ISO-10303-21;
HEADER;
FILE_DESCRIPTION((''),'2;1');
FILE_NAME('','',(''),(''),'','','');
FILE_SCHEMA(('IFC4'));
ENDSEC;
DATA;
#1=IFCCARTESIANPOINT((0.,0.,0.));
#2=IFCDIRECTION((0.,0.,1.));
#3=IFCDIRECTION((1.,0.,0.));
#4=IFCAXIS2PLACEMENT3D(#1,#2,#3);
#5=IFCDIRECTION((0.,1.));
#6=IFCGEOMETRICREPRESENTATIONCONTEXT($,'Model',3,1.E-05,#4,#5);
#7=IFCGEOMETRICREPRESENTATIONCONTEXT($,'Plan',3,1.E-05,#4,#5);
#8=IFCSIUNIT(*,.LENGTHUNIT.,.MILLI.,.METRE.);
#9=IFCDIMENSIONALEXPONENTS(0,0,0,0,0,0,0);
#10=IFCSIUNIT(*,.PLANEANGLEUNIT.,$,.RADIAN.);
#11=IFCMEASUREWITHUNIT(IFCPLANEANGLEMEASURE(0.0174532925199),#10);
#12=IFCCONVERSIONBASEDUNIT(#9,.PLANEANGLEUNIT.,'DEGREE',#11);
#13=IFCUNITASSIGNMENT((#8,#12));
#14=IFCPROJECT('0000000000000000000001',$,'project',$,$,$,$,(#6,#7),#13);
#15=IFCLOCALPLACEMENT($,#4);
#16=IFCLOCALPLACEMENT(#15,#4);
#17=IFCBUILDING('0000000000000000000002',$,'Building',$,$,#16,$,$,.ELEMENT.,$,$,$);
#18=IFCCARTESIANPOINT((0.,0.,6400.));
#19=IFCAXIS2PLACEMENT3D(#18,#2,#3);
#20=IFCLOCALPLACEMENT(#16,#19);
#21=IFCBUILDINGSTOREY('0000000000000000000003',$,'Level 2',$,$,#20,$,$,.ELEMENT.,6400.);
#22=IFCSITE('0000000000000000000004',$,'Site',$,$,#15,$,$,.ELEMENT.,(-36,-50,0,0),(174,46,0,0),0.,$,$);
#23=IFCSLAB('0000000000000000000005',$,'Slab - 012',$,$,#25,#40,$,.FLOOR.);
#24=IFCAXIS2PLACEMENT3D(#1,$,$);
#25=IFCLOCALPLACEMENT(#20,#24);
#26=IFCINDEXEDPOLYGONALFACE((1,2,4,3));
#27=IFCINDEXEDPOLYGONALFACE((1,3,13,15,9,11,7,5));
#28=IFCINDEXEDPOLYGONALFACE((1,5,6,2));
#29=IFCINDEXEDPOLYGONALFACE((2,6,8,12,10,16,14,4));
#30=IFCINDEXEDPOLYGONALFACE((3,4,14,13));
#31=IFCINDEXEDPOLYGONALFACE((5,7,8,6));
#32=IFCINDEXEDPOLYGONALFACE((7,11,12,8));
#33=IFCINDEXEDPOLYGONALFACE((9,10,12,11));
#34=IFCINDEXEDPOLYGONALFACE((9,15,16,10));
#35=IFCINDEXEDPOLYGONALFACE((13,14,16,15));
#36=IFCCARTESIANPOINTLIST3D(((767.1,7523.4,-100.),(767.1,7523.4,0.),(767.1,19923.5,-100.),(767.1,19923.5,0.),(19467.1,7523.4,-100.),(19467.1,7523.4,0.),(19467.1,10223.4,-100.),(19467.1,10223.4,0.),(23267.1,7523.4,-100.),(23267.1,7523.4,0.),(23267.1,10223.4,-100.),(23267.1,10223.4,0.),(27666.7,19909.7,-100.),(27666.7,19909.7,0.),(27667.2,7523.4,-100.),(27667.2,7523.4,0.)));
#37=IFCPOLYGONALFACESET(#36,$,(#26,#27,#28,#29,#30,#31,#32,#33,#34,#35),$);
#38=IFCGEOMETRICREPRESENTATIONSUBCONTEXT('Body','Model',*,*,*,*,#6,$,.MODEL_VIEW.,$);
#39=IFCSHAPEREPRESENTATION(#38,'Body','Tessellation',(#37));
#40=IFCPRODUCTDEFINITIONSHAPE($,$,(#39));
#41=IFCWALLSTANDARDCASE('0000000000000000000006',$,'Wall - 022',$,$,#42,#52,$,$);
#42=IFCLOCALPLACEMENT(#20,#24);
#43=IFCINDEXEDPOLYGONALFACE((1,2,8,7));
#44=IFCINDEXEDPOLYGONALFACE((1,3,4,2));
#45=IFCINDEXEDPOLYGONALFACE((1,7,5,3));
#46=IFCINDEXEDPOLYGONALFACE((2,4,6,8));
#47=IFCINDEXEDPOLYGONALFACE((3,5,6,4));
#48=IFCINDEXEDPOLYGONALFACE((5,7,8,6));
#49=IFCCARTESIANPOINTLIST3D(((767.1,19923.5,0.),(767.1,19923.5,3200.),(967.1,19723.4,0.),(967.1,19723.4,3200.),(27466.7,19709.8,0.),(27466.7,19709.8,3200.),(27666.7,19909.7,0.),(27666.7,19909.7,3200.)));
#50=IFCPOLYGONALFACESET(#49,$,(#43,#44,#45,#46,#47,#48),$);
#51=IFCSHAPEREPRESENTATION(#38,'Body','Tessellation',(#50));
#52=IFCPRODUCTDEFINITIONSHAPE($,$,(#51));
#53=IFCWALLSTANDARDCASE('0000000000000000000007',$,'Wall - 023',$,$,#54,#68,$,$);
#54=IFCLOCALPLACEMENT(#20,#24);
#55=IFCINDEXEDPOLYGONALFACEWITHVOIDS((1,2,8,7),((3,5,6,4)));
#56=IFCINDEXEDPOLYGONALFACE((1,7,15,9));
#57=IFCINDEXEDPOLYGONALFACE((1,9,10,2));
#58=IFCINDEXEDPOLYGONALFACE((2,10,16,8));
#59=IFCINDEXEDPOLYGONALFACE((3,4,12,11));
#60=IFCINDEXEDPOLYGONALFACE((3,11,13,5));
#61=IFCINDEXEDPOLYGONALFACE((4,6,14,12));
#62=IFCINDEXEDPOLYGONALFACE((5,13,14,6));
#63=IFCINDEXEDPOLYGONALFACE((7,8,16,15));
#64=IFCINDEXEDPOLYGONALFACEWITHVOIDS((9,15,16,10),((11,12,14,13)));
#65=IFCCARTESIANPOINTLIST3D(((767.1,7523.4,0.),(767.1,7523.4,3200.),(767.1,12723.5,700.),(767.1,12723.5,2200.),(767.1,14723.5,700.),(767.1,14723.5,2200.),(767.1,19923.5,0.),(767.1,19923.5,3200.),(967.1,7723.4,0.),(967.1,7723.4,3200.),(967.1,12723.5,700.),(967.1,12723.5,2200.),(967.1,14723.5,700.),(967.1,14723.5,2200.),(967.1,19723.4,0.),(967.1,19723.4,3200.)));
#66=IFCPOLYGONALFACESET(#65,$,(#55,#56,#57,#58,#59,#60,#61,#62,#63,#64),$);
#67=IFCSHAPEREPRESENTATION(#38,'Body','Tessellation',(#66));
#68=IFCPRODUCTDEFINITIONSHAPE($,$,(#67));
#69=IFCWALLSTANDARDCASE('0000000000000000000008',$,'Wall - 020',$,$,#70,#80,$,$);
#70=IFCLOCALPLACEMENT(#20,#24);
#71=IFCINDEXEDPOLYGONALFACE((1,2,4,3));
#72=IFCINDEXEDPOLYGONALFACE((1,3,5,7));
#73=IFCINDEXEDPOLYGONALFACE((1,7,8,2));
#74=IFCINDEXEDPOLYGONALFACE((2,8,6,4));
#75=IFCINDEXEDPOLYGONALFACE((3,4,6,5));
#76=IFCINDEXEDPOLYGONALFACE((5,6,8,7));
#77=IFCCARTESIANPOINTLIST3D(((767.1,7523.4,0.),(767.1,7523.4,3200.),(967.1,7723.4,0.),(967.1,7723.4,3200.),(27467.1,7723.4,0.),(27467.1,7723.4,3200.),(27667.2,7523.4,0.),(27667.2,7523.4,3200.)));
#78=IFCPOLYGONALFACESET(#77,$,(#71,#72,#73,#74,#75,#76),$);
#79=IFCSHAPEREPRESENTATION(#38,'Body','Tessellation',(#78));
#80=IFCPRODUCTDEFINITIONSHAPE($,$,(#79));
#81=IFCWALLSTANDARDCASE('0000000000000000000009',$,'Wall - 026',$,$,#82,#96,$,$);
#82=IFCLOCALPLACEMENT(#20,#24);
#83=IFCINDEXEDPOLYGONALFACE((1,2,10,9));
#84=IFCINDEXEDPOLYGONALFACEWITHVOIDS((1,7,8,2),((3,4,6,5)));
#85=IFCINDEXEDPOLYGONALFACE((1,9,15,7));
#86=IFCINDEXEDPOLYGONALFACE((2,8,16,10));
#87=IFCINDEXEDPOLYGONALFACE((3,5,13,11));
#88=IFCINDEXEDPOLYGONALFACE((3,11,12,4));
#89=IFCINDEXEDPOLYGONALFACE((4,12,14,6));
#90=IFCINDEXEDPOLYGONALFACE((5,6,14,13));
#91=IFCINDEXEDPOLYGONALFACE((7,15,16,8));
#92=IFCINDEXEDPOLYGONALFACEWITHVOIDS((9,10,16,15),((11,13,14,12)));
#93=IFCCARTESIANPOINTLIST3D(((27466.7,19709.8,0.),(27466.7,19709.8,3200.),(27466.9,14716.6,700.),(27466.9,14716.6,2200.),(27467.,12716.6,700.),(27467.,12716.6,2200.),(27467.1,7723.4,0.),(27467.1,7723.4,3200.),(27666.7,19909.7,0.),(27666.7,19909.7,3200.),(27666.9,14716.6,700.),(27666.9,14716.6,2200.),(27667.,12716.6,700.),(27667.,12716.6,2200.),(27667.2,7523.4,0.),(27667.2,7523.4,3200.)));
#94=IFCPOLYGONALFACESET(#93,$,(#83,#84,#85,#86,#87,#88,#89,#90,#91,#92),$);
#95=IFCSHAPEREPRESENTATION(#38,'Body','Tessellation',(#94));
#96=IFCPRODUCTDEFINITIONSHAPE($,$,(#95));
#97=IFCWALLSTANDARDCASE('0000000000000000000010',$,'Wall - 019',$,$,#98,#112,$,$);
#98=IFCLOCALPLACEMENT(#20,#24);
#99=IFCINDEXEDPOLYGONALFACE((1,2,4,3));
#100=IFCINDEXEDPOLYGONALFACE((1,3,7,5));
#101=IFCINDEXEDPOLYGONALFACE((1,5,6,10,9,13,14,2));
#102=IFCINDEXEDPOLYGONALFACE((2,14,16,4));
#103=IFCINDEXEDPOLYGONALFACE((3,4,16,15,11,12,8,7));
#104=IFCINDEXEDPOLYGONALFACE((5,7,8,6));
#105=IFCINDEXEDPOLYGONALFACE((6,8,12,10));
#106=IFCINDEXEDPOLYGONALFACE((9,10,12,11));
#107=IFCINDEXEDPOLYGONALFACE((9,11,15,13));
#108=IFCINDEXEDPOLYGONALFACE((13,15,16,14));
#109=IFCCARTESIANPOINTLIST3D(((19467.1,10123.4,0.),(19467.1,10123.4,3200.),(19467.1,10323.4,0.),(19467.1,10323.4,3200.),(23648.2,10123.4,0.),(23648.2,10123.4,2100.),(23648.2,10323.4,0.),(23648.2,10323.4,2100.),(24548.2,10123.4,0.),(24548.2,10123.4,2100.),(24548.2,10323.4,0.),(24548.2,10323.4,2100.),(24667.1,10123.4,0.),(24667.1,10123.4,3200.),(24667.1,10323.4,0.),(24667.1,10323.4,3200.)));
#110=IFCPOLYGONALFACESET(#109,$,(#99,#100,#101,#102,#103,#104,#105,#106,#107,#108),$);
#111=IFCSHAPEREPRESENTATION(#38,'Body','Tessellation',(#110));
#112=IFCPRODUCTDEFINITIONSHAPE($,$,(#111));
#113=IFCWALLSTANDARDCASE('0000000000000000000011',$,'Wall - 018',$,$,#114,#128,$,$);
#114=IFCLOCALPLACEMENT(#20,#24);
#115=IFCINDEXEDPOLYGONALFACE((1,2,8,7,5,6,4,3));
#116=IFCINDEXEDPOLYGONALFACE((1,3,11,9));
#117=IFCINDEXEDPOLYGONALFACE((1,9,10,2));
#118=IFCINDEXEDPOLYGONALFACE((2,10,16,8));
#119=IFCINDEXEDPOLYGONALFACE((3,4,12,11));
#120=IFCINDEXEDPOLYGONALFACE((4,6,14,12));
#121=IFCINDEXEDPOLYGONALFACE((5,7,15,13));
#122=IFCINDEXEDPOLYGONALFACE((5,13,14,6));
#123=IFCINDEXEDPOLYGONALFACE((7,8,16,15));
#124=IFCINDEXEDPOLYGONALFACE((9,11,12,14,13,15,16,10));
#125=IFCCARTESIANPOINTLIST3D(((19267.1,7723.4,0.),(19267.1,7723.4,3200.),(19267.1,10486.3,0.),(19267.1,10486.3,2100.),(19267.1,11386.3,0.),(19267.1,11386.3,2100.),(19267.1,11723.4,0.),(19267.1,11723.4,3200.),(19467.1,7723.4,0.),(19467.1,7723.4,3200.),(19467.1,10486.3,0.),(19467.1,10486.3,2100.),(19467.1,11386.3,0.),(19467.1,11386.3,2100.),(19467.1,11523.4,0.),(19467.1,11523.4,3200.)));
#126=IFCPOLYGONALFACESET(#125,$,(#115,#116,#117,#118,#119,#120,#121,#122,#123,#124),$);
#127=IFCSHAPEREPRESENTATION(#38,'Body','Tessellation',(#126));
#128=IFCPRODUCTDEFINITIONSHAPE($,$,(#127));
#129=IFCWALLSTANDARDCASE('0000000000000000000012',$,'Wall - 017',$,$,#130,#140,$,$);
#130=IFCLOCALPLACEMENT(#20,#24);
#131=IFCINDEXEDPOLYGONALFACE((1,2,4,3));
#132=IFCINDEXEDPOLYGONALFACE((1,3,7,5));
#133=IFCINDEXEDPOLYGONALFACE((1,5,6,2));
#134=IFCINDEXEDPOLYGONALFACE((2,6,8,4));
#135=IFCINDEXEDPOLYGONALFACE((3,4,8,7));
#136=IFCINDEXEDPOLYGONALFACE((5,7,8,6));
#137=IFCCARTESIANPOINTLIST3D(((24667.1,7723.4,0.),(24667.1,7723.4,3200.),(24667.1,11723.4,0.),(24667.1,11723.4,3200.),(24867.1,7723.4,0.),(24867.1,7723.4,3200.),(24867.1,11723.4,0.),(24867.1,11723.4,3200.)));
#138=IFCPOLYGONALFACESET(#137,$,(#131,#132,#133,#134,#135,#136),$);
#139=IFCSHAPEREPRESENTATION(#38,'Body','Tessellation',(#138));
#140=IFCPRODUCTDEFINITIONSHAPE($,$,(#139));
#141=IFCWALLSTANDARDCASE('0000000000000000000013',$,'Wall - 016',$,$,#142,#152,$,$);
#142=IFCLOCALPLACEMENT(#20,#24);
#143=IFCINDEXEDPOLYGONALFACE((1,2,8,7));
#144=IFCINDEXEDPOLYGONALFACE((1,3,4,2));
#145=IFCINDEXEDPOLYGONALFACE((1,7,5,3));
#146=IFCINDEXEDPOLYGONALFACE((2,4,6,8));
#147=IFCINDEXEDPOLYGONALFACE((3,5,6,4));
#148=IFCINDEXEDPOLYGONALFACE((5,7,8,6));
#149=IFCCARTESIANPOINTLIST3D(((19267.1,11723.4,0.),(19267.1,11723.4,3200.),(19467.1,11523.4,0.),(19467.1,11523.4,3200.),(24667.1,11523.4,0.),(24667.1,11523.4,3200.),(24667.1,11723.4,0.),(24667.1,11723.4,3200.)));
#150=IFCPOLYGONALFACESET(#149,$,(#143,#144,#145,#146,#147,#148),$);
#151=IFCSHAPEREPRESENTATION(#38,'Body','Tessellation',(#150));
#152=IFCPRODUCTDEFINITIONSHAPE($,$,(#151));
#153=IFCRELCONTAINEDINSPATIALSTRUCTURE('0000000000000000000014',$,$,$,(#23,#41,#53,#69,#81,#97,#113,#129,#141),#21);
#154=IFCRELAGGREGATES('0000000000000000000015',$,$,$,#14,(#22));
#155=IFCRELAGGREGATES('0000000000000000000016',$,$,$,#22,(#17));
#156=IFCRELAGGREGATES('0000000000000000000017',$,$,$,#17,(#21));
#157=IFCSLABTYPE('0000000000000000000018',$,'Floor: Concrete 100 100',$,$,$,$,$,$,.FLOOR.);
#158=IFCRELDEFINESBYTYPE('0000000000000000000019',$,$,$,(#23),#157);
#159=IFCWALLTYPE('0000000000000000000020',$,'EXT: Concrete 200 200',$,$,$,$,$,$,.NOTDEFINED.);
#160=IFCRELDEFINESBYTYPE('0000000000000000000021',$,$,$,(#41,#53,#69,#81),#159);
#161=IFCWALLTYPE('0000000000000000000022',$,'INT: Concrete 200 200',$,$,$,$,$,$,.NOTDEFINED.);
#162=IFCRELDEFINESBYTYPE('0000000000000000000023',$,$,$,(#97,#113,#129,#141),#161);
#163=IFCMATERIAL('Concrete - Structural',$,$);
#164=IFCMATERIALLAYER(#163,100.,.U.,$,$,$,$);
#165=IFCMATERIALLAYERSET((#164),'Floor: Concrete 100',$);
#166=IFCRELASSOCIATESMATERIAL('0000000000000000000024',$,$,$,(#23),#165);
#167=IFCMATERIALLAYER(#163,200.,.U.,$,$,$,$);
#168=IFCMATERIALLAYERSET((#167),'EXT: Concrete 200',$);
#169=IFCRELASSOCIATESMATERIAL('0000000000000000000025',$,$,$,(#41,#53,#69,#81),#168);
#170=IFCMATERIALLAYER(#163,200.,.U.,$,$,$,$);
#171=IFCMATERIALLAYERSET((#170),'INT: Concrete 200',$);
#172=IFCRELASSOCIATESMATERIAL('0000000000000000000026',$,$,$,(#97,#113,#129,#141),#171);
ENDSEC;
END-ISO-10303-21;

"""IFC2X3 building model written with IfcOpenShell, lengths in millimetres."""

from ifc_helpers import new_model, entity, si_unit, converted_unit, direction, frame, origin_with_axes, origin_2d_with_axis, place, context, subcontext, project, spatial, polyline, rectangle, outline, extrude, material, layer, layer_set, layer_usage, type_object, element, save


model = new_model("IFC2X3")

# Units and contexts
model_context = context("Model", 3, precision=1e-05, world=origin_with_axes(), true_north=direction((0.0, 1.0)))
plan_context = context("Plan", 3, precision=1e-05, world=origin_with_axes(), true_north=direction((0.0, 1.0)))
body_context = subcontext(model_context, "Body", "Model", "MODEL_VIEW")
ifc_project = project(units=[si_unit("LENGTHUNIT", "METRE", prefix="MILLI"), converted_unit("PLANEANGLEUNIT", "DEGREE", entity("IfcPlaneAngleMeasure", 0.0174532925199), si_unit("PLANEANGLEUNIT", "RADIAN"), dimensions=[0, 0, 0, 0, 0, 0, 0])], contexts=[model_context, plan_context])

# Site, building, storey
site_placement = place(None, origin_with_axes())
site = spatial("IfcSite", under=ifc_project, at=site_placement, Name="Site", CompositionType="ELEMENT", RefLatitude=(-36, -50, 0, 0), RefLongitude=(174, 46, 0, 0), RefElevation=0.0)
building_placement = place(site_placement, origin_with_axes())
building = spatial("IfcBuilding", under=site, at=building_placement, Name="Building", CompositionType="ELEMENT")
storey_placement = place(building_placement, frame((0.0, 0.0, 6400.0), z_axis=(0.0, 0.0, 1.0), x_axis=(1.0, 0.0, 0.0)))
storey = spatial("IfcBuildingStorey", under=building, at=storey_placement, Name="Level 2", CompositionType="ELEMENT", Elevation=6400.0)

# Slab
ifc_material = material(Name="Concrete - Structural")
ifc_layer_1 = layer(ifc_material, 100.0, ventilated="UNKNOWN")
ifc_layer_set_1 = layer_set([ifc_layer_1], Name="Floor: Concrete 100")
ifc_layer_usage_1 = layer_usage(ifc_layer_set_1, "AXIS3", "NEGATIVE", 100.0)
slab_type = type_object("IfcSlabType", Name="Floor: Concrete 100 100", PredefinedType="FLOOR")
slab_placement = place(storey_placement, frame((767.1, 19923.5, 0.0), z_axis=(0.0, 0.0, 1.0), x_axis=(1.0, 0.0, 0.0)))
element("IfcSlab", 1, at=slab_placement, inside=storey, type_object=slab_type, material=ifc_layer_usage_1, Name="Slab - 012", PredefinedType="FLOOR", context=body_context, shape_type="SweptSolid", body=[
    extrude(outline(polyline([(0.0, 0.0), (0.0, -12400.1), (18700.0, -12400.1), (18700.0, -9700.1), (22500.0, -9700.1), (22500.0, -12400.1), (26900.0, -12400.1), (26899.5, -13.8), (0.0, 0.0)])), frame((0.0, 0.0, -100.0), z_axis=(0.0, 0.0, 1.0), x_axis=(1.0, 0.0, 0.0)), (0.0, 0.0, 1.0), 100.0),
])

# Wall
ifc_layer_2 = layer(ifc_material, 200.0, ventilated="UNKNOWN")
ifc_layer_set_2 = layer_set([ifc_layer_2], Name="EXT: Concrete 200")
ifc_layer_usage_2 = layer_usage(ifc_layer_set_2, "AXIS2", "POSITIVE", 0.0)
wall_type_1 = type_object("IfcWallType", Name="EXT: Concrete 200 200", PredefinedType="NOTDEFINED")
wall_1_placement = place(storey_placement, frame((967.1, 19723.4, 0.0), z_axis=(0.0, 0.0, 1.0), x_axis=(1.0, -0.000513, 0.0)))
element("IfcWallStandardCase", 2, at=wall_1_placement, inside=storey, type_object=wall_type_1, material=ifc_layer_usage_2, Name="Wall - 022", context=body_context, shape_type="SweptSolid", body=[
    extrude(outline(polyline([(0.0, 0.0), (26499.5, 0.0), (26699.4, 200.0), (-200.1, 200.0), (0.0, 0.0)])), origin_with_axes(), (0.0, 0.0, 1.0), 3200.0),
])

# Wall, opening
ifc_layer_usage_3 = layer_usage(ifc_layer_set_2, "AXIS2", "POSITIVE", -200.0)
wall_2_placement = place(storey_placement, frame((967.1, 19723.4, 0.0), z_axis=(0.0, 0.0, 1.0), x_axis=(0.0, -1.0, 0.0)))
wall_2 = element("IfcWallStandardCase", 3, at=wall_2_placement, inside=storey, type_object=wall_type_1, material=ifc_layer_usage_3, Name="Wall - 023", context=body_context, shape_type="SweptSolid", body=[
    extrude(outline(polyline([(-200.1, -200.0), (12200.0, -200.0), (12000.0, 0.0), (0.0, 0.0), (-200.1, -200.0)])), origin_with_axes(), (0.0, 0.0, 1.0), 3200.0),
])
opening_1_placement = place(wall_2_placement, frame((5999.9, 0.0, 700.0), z_axis=(0.0, 0.0, 1.0), x_axis=(1.0, 0.0, 0.0)))
element("IfcOpeningElement", 4, at=opening_1_placement, cuts=wall_2, context=body_context, shape_type="SweptSolid", body=[
    extrude(rectangle(XDim=2000.0, YDim=1500.0, at=origin_2d_with_axis()), frame((0.0, 200.0, 750.0), z_axis=(0.0, 1.0, 0.0), x_axis=(1.0, 0.0, 0.0)), (0.0, 0.0, -1.0), 600.0),
])

# Wall
ifc_layer_usage_4 = layer_usage(ifc_layer_set_2, "AXIS2", "POSITIVE", 0.0)
wall_3_placement = place(storey_placement, frame((27667.1, 7723.4, 0.0), z_axis=(0.0, 0.0, 1.0), x_axis=(-1.0, 0.0, 0.0)))
element("IfcWallStandardCase", 5, at=wall_3_placement, inside=storey, type_object=wall_type_1, material=ifc_layer_usage_4, Name="Wall - 020", context=body_context, shape_type="SweptSolid", body=[
    extrude(outline(polyline([(200.0, 0.0), (26700.0, 0.0), (26900.0, 200.0), (0.0, 200.0), (200.0, 0.0)])), origin_with_axes(), (0.0, 0.0, 1.0), 3200.0),
])

# Walls, openings
ifc_layer_usage_5 = layer_usage(ifc_layer_set_2, "AXIS2", "POSITIVE", -200.0)
wall_4_placement = place(storey_placement, frame((27666.7, 19709.7, 0.0), z_axis=(0.0, 0.0, 1.0), x_axis=(0.000039, -1.0, 0.0)))
wall_4 = element("IfcWallStandardCase", 6, at=wall_4_placement, inside=storey, type_object=wall_type_1, material=ifc_layer_usage_5, Name="Wall - 026", context=body_context, shape_type="SweptSolid", body=[
    extrude(outline(polyline([(-0.1, -200.0), (11986.3, -200.0), (12186.3, 0.0), (-200.0, 0.0), (-0.1, -200.0)])), origin_with_axes(), (0.0, 0.0, 1.0), 3200.0),
])
opening_2_placement = place(wall_4_placement, frame((5993.2, 0.0, 700.0), z_axis=(0.0, 0.0, 1.0), x_axis=(1.0, 0.0, 0.0)))
element("IfcOpeningElement", 7, at=opening_2_placement, cuts=wall_4, context=body_context, shape_type="SweptSolid", body=[
    extrude(rectangle(XDim=2000.0, YDim=1500.0, at=origin_2d_with_axis()), frame((0.0, -200.0, 750.0), z_axis=(0.0, -1.0, 0.0), x_axis=(-1.0, 0.0, 0.0)), (0.0, 0.0, -1.0), 600.0),
])
ifc_layer_3 = layer(ifc_material, 200.0, ventilated="UNKNOWN")
ifc_layer_set_3 = layer_set([ifc_layer_3], Name="INT: Concrete 200")
ifc_layer_usage_6 = layer_usage(ifc_layer_set_3, "AXIS2", "POSITIVE", -200.0)
wall_type_2 = type_object("IfcWallType", Name="INT: Concrete 200 200", PredefinedType="NOTDEFINED")
wall_5_placement = place(storey_placement, frame((19467.1, 10323.4, 0.0), z_axis=(0.0, 0.0, 1.0), x_axis=(1.0, 0.0, 0.0)))
wall_5 = element("IfcWallStandardCase", 8, at=wall_5_placement, inside=storey, type_object=wall_type_2, material=ifc_layer_usage_6, Name="Wall - 019", context=body_context, shape_type="SweptSolid", body=[
    extrude(outline(polyline([(0.0, -200.0), (5200.0, -200.0), (5200.0, 0.0), (0.0, 0.0), (0.0, -200.0)])), origin_with_axes(), (0.0, 0.0, 1.0), 3200.0),
])
opening_3_placement = place(wall_5_placement, frame((4631.0, 0.0, 0.0), z_axis=(0.0, 0.0, 1.0), x_axis=(1.0, 0.0, 0.0)))
element("IfcOpeningElement", 9, at=opening_3_placement, cuts=wall_5, context=body_context, shape_type="SweptSolid", body=[
    extrude(rectangle(XDim=900.0, YDim=2100.0, at=origin_2d_with_axis()), frame((0.0, 200.0, 1050.0), z_axis=(0.0, 1.0, 0.0), x_axis=(1.0, 0.0, 0.0)), (0.0, 0.0, -1.0), 600.0),
])
ifc_layer_usage_7 = layer_usage(ifc_layer_set_3, "AXIS2", "POSITIVE", -200.0)
wall_6_placement = place(storey_placement, frame((19467.1, 11523.4, 0.0), z_axis=(0.0, 0.0, 1.0), x_axis=(0.0, -1.0, 0.0)))
wall_6 = element("IfcWallStandardCase", 10, at=wall_6_placement, inside=storey, type_object=wall_type_2, material=ifc_layer_usage_7, Name="Wall - 018", context=body_context, shape_type="SweptSolid", body=[
    extrude(outline(polyline([(-200.0, -200.0), (3800.0, -200.0), (3800.0, 0.0), (0.0, 0.0), (-200.0, -200.0)])), origin_with_axes(), (0.0, 0.0, 1.0), 3200.0),
])
opening_4_placement = place(wall_6_placement, frame((587.1, 0.0, 0.0), z_axis=(0.0, 0.0, 1.0), x_axis=(1.0, 0.0, 0.0)))
element("IfcOpeningElement", 11, at=opening_4_placement, cuts=wall_6, context=body_context, shape_type="SweptSolid", body=[
    extrude(rectangle(XDim=900.0, YDim=2100.0, at=origin_2d_with_axis()), frame((0.0, -200.0, 1050.0), z_axis=(0.0, 1.0, 0.0), x_axis=(1.0, 0.0, 0.0)), (0.0, 0.0, 1.0), 600.0),
])

# Walls
ifc_layer_usage_8 = layer_usage(ifc_layer_set_3, "AXIS2", "POSITIVE", 0.0)
wall_7_placement = place(storey_placement, frame((24667.1, 11723.4, 0.0), z_axis=(0.0, 0.0, 1.0), x_axis=(0.0, -1.0, 0.0)))
element("IfcWallStandardCase", 12, at=wall_7_placement, inside=storey, type_object=wall_type_2, material=ifc_layer_usage_8, Name="Wall - 017", context=body_context, shape_type="SweptSolid", body=[
    extrude(outline(polyline([(0.0, 0.0), (4000.0, 0.0), (4000.0, 200.0), (0.0, 200.0), (0.0, 0.0)])), origin_with_axes(), (0.0, 0.0, 1.0), 3200.0),
])
ifc_layer_usage_9 = layer_usage(ifc_layer_set_3, "AXIS2", "POSITIVE", 0.0)
wall_8_placement = place(storey_placement, frame((19467.1, 11523.4, 0.0), z_axis=(0.0, 0.0, 1.0), x_axis=(1.0, 0.0, 0.0)))
element("IfcWallStandardCase", 13, at=wall_8_placement, inside=storey, type_object=wall_type_2, material=ifc_layer_usage_9, Name="Wall - 016", context=body_context, shape_type="SweptSolid", body=[
    extrude(outline(polyline([(0.0, 0.0), (5200.0, 0.0), (5200.0, 200.0), (-200.0, 200.0), (0.0, 0.0)])), origin_with_axes(), (0.0, 0.0, 1.0), 3200.0),
])

save(model, "model.ifc")
